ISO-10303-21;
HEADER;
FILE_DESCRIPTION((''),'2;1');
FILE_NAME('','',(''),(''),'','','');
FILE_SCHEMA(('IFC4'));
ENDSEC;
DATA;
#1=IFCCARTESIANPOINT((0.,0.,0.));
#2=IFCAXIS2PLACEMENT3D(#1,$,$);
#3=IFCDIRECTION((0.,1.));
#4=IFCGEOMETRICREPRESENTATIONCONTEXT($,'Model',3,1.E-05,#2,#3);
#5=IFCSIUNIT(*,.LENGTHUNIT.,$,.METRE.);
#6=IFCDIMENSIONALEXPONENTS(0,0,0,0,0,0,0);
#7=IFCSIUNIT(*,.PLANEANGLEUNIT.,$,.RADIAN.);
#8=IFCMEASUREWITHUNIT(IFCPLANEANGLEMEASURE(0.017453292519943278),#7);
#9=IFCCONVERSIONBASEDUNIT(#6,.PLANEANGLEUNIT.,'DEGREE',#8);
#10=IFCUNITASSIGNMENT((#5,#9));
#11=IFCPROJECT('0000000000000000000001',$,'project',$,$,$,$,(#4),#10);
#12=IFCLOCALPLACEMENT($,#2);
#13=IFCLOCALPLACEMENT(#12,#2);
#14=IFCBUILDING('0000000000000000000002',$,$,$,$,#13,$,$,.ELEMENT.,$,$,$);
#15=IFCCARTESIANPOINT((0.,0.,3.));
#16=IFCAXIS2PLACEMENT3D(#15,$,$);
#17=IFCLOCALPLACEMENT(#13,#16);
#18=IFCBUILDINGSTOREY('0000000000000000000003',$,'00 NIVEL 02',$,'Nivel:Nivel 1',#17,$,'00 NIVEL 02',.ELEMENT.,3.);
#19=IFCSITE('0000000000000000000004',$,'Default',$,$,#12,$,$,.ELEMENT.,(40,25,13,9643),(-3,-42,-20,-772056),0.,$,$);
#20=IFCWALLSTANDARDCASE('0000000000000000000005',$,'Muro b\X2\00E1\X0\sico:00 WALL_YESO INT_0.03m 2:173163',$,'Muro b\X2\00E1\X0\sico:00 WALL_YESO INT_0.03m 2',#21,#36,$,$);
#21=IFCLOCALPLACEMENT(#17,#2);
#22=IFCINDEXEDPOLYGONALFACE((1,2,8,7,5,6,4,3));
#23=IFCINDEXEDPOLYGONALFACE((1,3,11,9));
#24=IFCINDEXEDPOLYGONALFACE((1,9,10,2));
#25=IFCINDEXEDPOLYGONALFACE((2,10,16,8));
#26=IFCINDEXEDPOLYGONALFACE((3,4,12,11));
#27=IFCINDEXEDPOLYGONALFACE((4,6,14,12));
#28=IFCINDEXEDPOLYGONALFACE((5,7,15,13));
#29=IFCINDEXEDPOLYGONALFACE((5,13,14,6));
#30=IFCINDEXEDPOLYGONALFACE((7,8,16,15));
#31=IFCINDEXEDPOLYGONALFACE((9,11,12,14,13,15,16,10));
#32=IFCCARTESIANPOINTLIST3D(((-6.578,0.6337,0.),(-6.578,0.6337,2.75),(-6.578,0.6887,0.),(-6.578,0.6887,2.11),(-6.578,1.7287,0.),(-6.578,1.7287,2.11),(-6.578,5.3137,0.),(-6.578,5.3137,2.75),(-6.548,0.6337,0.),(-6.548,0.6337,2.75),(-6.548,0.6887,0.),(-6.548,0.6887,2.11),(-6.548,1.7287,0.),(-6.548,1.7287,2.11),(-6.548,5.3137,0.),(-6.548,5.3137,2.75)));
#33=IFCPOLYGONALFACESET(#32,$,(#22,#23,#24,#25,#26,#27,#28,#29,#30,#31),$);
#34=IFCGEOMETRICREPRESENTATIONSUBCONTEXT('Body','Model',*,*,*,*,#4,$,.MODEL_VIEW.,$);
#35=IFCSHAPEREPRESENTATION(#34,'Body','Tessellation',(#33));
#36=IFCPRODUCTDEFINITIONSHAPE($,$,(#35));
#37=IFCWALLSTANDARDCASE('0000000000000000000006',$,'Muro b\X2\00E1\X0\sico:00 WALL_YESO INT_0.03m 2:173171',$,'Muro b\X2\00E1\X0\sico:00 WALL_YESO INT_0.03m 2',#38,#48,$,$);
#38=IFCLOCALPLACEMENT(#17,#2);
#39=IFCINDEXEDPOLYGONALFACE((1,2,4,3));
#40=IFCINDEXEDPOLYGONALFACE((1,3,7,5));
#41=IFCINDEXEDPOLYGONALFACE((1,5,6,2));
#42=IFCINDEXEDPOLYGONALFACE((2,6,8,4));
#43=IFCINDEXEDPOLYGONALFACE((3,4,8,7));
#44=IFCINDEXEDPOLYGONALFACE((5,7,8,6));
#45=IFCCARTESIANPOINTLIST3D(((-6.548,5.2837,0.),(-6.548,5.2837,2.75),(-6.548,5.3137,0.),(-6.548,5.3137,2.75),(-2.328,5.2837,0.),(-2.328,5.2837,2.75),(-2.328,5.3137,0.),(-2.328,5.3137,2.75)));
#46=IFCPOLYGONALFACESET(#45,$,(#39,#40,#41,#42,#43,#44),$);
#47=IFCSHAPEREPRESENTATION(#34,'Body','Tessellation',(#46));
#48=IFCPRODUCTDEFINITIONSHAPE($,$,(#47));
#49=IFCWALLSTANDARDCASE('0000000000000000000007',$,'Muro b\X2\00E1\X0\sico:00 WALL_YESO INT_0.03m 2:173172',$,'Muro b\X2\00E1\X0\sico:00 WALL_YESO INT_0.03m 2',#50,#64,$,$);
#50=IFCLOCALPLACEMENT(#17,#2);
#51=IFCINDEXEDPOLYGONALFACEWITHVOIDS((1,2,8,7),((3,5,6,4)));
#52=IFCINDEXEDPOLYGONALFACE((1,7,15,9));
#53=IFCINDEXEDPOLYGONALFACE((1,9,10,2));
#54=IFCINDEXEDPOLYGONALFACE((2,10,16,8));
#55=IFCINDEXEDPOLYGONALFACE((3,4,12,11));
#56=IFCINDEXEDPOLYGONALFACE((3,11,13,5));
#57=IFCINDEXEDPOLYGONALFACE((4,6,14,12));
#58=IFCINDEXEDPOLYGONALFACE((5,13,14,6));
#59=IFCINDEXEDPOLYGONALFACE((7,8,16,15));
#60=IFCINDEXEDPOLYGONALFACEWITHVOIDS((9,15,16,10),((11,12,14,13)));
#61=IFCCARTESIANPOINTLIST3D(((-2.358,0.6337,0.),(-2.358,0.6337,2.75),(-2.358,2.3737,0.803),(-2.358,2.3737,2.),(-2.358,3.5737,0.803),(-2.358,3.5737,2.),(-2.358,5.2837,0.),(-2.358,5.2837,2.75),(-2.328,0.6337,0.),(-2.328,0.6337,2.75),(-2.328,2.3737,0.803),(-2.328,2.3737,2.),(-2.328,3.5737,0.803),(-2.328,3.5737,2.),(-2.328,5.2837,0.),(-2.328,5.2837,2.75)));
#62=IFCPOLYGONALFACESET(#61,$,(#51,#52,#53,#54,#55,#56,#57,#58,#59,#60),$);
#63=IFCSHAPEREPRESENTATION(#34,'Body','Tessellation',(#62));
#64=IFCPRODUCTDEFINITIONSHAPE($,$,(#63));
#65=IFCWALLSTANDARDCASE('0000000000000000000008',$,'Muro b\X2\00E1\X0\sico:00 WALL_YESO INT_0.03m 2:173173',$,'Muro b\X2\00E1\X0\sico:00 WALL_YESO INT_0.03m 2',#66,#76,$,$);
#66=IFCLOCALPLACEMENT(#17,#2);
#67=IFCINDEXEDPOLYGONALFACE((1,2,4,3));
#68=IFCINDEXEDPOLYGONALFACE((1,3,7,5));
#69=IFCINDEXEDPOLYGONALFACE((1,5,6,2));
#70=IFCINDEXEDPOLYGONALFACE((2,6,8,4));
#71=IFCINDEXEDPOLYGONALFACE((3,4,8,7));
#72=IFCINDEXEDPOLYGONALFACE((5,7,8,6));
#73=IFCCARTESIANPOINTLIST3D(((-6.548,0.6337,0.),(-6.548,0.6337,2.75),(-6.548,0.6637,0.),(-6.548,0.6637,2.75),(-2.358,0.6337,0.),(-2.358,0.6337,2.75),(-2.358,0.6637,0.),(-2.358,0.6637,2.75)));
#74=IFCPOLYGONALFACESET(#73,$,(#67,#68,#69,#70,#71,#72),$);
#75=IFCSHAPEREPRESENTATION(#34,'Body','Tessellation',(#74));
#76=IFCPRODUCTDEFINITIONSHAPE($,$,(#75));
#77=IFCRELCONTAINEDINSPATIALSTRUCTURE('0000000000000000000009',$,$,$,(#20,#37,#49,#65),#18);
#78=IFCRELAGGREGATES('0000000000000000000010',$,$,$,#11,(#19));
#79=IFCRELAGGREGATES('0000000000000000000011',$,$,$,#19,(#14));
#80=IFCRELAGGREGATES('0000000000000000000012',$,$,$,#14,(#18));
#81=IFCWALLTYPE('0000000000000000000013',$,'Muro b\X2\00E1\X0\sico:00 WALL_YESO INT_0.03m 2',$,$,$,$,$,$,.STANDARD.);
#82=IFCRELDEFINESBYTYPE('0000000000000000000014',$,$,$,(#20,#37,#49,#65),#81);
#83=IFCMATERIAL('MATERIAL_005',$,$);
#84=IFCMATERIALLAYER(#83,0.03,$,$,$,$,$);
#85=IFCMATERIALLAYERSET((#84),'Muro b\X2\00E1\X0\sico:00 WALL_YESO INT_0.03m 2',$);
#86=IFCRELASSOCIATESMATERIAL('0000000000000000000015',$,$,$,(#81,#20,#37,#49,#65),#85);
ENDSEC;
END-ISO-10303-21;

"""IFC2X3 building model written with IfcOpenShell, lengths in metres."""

from ifc_helpers import new_model, entity, si_unit, converted_unit, direction, frame, frame_2d, origin, place, context, subcontext, project, spatial, rectangle, extrude, material, layer, layer_set, layer_usage, type_object, element, save


model = new_model("IFC2X3")

# Units and contexts
model_context = context("Model", 3, precision=1e-05, world=origin(), true_north=direction((0.0, 1.0)))
body_context = subcontext(model_context, "Body", "Model", "MODEL_VIEW")
ifc_project = project(units=[si_unit("LENGTHUNIT", "METRE"), converted_unit("PLANEANGLEUNIT", "DEGREE", entity("IfcPlaneAngleMeasure", 0.017453292519943278), si_unit("PLANEANGLEUNIT", "RADIAN"), dimensions=[0, 0, 0, 0, 0, 0, 0])], contexts=[model_context])

# Site, building, storey
site_placement = place(None, origin())
site = spatial("IfcSite", under=ifc_project, at=site_placement, Name="Default", CompositionType="ELEMENT", RefLatitude=(40, 25, 13, 9643), RefLongitude=(-3, -42, -20, -772056), RefElevation=0.0)
building_placement = place(site_placement, origin())
building = spatial("IfcBuilding", under=site, at=building_placement, CompositionType="ELEMENT")
storey_placement = place(building_placement, frame((0.0, 0.0, 3.0)))
storey = spatial("IfcBuildingStorey", under=building, at=storey_placement, Name="00 NIVEL 02", ObjectType="Nivel:Nivel 1", LongName="00 NIVEL 02", CompositionType="ELEMENT", Elevation=3.0)

# Wall, opening
ifc_material_1 = material(Name="MATERIAL_005")
ifc_layer_1 = layer(ifc_material_1, 0.03)
ifc_layer_set_1 = layer_set([ifc_layer_1], Name="Muro básico:00 WALL_YESO INT_0.03m 2")
ifc_layer_usage_1 = layer_usage(ifc_layer_set_1, "AXIS2", "POSITIVE", -0.015)
wall_type_1 = type_object("IfcWallType", Name="Muro básico:00 WALL_YESO INT_0.03m 2", PredefinedType="STANDARD", material=ifc_layer_set_1)
wall_1_placement = place(storey_placement, frame((-6.563, 5.3137, 0.0), z_axis=(0.0, 0.0, 1.0), x_axis=(0.0, -1.0, 0.0)))
wall_1 = element("IfcWallStandardCase", 1, at=wall_1_placement, inside=storey, type_object=wall_type_1, material=ifc_layer_usage_1, Name="Muro básico:00 WALL_YESO INT_0.03m 2:173163", ObjectType="Muro básico:00 WALL_YESO INT_0.03m 2", context=body_context, shape_type="SweptSolid", body=[
    extrude(rectangle(XDim=4.68, YDim=0.03, at=frame_2d((2.34, 0.0), x_axis=(-1.0, 0.0))), origin(), (0.0, 0.0, 1.0), 2.75),
])
opening_1_placement = place(wall_1_placement, origin())
element("IfcOpeningElement", 2, at=opening_1_placement, cuts=wall_1, ObjectType="Opening", context=body_context, shape_type="SweptSolid", body=[
    extrude(rectangle(XDim=2.11, YDim=1.04, at=frame_2d((0.0, 0.0), x_axis=(0.0, 1.0))), frame((4.105, 0.015, 1.055), z_axis=(0.0, -1.0, 0.0), x_axis=(1.0, 0.0, 0.0)), (0.0, 0.0, 1.0), 0.03),
])

# Wall
ifc_layer_usage_2 = layer_usage(ifc_layer_set_1, "AXIS2", "NEGATIVE", 0.015)
wall_2_placement = place(storey_placement, frame((-6.548, 5.2987, 0.0)))
element("IfcWallStandardCase", 3, at=wall_2_placement, inside=storey, type_object=wall_type_1, material=ifc_layer_usage_2, Name="Muro básico:00 WALL_YESO INT_0.03m 2:173171", ObjectType="Muro básico:00 WALL_YESO INT_0.03m 2", context=body_context, shape_type="SweptSolid", body=[
    extrude(rectangle(XDim=4.22, YDim=0.03, at=frame_2d((2.11, 0.0), x_axis=(-1.0, 0.0))), origin(), (0.0, 0.0, 1.0), 2.75),
])

# Wall, opening
ifc_layer_usage_3 = layer_usage(ifc_layer_set_1, "AXIS2", "NEGATIVE", 0.015)
wall_3_placement = place(storey_placement, frame((-2.343, 5.2837, 0.0), z_axis=(0.0, 0.0, 1.0), x_axis=(0.0, -1.0, 0.0)))
wall_3 = element("IfcWallStandardCase", 4, at=wall_3_placement, inside=storey, type_object=wall_type_1, material=ifc_layer_usage_3, Name="Muro básico:00 WALL_YESO INT_0.03m 2:173172", ObjectType="Muro básico:00 WALL_YESO INT_0.03m 2", context=body_context, shape_type="SweptSolid", body=[
    extrude(rectangle(XDim=4.65, YDim=0.03, at=frame_2d((2.325, 0.0), x_axis=(-1.0, 0.0))), origin(), (0.0, 0.0, 1.0), 2.75),
])
opening_2_placement = place(wall_3_placement, origin())
element("IfcOpeningElement", 5, at=opening_2_placement, cuts=wall_3, ObjectType="Opening", context=body_context, shape_type="SweptSolid", body=[
    extrude(rectangle(XDim=1.197, YDim=1.2, at=frame_2d((0.0, 0.0), x_axis=(0.0, 1.0))), frame((2.31, 0.015, 1.4015), z_axis=(0.0, -1.0, 0.0), x_axis=(1.0, 0.0, 0.0)), (0.0, 0.0, 1.0), 0.03),
])

# Wall
ifc_layer_usage_4 = layer_usage(ifc_layer_set_1, "AXIS2", "NEGATIVE", 0.015)
wall_4_placement = place(storey_placement, frame((-2.358, 0.6487, 0.0), z_axis=(0.0, 0.0, 1.0), x_axis=(-1.0, 0.0, 0.0)))
element("IfcWallStandardCase", 6, at=wall_4_placement, inside=storey, type_object=wall_type_1, material=ifc_layer_usage_4, Name="Muro básico:00 WALL_YESO INT_0.03m 2:173173", ObjectType="Muro básico:00 WALL_YESO INT_0.03m 2", context=body_context, shape_type="SweptSolid", body=[
    extrude(rectangle(XDim=4.19, YDim=0.03, at=frame_2d((2.095, 0.0), x_axis=(-1.0, 0.0))), origin(), (0.0, 0.0, 1.0), 2.75),
])

save(model, "model.ifc")
